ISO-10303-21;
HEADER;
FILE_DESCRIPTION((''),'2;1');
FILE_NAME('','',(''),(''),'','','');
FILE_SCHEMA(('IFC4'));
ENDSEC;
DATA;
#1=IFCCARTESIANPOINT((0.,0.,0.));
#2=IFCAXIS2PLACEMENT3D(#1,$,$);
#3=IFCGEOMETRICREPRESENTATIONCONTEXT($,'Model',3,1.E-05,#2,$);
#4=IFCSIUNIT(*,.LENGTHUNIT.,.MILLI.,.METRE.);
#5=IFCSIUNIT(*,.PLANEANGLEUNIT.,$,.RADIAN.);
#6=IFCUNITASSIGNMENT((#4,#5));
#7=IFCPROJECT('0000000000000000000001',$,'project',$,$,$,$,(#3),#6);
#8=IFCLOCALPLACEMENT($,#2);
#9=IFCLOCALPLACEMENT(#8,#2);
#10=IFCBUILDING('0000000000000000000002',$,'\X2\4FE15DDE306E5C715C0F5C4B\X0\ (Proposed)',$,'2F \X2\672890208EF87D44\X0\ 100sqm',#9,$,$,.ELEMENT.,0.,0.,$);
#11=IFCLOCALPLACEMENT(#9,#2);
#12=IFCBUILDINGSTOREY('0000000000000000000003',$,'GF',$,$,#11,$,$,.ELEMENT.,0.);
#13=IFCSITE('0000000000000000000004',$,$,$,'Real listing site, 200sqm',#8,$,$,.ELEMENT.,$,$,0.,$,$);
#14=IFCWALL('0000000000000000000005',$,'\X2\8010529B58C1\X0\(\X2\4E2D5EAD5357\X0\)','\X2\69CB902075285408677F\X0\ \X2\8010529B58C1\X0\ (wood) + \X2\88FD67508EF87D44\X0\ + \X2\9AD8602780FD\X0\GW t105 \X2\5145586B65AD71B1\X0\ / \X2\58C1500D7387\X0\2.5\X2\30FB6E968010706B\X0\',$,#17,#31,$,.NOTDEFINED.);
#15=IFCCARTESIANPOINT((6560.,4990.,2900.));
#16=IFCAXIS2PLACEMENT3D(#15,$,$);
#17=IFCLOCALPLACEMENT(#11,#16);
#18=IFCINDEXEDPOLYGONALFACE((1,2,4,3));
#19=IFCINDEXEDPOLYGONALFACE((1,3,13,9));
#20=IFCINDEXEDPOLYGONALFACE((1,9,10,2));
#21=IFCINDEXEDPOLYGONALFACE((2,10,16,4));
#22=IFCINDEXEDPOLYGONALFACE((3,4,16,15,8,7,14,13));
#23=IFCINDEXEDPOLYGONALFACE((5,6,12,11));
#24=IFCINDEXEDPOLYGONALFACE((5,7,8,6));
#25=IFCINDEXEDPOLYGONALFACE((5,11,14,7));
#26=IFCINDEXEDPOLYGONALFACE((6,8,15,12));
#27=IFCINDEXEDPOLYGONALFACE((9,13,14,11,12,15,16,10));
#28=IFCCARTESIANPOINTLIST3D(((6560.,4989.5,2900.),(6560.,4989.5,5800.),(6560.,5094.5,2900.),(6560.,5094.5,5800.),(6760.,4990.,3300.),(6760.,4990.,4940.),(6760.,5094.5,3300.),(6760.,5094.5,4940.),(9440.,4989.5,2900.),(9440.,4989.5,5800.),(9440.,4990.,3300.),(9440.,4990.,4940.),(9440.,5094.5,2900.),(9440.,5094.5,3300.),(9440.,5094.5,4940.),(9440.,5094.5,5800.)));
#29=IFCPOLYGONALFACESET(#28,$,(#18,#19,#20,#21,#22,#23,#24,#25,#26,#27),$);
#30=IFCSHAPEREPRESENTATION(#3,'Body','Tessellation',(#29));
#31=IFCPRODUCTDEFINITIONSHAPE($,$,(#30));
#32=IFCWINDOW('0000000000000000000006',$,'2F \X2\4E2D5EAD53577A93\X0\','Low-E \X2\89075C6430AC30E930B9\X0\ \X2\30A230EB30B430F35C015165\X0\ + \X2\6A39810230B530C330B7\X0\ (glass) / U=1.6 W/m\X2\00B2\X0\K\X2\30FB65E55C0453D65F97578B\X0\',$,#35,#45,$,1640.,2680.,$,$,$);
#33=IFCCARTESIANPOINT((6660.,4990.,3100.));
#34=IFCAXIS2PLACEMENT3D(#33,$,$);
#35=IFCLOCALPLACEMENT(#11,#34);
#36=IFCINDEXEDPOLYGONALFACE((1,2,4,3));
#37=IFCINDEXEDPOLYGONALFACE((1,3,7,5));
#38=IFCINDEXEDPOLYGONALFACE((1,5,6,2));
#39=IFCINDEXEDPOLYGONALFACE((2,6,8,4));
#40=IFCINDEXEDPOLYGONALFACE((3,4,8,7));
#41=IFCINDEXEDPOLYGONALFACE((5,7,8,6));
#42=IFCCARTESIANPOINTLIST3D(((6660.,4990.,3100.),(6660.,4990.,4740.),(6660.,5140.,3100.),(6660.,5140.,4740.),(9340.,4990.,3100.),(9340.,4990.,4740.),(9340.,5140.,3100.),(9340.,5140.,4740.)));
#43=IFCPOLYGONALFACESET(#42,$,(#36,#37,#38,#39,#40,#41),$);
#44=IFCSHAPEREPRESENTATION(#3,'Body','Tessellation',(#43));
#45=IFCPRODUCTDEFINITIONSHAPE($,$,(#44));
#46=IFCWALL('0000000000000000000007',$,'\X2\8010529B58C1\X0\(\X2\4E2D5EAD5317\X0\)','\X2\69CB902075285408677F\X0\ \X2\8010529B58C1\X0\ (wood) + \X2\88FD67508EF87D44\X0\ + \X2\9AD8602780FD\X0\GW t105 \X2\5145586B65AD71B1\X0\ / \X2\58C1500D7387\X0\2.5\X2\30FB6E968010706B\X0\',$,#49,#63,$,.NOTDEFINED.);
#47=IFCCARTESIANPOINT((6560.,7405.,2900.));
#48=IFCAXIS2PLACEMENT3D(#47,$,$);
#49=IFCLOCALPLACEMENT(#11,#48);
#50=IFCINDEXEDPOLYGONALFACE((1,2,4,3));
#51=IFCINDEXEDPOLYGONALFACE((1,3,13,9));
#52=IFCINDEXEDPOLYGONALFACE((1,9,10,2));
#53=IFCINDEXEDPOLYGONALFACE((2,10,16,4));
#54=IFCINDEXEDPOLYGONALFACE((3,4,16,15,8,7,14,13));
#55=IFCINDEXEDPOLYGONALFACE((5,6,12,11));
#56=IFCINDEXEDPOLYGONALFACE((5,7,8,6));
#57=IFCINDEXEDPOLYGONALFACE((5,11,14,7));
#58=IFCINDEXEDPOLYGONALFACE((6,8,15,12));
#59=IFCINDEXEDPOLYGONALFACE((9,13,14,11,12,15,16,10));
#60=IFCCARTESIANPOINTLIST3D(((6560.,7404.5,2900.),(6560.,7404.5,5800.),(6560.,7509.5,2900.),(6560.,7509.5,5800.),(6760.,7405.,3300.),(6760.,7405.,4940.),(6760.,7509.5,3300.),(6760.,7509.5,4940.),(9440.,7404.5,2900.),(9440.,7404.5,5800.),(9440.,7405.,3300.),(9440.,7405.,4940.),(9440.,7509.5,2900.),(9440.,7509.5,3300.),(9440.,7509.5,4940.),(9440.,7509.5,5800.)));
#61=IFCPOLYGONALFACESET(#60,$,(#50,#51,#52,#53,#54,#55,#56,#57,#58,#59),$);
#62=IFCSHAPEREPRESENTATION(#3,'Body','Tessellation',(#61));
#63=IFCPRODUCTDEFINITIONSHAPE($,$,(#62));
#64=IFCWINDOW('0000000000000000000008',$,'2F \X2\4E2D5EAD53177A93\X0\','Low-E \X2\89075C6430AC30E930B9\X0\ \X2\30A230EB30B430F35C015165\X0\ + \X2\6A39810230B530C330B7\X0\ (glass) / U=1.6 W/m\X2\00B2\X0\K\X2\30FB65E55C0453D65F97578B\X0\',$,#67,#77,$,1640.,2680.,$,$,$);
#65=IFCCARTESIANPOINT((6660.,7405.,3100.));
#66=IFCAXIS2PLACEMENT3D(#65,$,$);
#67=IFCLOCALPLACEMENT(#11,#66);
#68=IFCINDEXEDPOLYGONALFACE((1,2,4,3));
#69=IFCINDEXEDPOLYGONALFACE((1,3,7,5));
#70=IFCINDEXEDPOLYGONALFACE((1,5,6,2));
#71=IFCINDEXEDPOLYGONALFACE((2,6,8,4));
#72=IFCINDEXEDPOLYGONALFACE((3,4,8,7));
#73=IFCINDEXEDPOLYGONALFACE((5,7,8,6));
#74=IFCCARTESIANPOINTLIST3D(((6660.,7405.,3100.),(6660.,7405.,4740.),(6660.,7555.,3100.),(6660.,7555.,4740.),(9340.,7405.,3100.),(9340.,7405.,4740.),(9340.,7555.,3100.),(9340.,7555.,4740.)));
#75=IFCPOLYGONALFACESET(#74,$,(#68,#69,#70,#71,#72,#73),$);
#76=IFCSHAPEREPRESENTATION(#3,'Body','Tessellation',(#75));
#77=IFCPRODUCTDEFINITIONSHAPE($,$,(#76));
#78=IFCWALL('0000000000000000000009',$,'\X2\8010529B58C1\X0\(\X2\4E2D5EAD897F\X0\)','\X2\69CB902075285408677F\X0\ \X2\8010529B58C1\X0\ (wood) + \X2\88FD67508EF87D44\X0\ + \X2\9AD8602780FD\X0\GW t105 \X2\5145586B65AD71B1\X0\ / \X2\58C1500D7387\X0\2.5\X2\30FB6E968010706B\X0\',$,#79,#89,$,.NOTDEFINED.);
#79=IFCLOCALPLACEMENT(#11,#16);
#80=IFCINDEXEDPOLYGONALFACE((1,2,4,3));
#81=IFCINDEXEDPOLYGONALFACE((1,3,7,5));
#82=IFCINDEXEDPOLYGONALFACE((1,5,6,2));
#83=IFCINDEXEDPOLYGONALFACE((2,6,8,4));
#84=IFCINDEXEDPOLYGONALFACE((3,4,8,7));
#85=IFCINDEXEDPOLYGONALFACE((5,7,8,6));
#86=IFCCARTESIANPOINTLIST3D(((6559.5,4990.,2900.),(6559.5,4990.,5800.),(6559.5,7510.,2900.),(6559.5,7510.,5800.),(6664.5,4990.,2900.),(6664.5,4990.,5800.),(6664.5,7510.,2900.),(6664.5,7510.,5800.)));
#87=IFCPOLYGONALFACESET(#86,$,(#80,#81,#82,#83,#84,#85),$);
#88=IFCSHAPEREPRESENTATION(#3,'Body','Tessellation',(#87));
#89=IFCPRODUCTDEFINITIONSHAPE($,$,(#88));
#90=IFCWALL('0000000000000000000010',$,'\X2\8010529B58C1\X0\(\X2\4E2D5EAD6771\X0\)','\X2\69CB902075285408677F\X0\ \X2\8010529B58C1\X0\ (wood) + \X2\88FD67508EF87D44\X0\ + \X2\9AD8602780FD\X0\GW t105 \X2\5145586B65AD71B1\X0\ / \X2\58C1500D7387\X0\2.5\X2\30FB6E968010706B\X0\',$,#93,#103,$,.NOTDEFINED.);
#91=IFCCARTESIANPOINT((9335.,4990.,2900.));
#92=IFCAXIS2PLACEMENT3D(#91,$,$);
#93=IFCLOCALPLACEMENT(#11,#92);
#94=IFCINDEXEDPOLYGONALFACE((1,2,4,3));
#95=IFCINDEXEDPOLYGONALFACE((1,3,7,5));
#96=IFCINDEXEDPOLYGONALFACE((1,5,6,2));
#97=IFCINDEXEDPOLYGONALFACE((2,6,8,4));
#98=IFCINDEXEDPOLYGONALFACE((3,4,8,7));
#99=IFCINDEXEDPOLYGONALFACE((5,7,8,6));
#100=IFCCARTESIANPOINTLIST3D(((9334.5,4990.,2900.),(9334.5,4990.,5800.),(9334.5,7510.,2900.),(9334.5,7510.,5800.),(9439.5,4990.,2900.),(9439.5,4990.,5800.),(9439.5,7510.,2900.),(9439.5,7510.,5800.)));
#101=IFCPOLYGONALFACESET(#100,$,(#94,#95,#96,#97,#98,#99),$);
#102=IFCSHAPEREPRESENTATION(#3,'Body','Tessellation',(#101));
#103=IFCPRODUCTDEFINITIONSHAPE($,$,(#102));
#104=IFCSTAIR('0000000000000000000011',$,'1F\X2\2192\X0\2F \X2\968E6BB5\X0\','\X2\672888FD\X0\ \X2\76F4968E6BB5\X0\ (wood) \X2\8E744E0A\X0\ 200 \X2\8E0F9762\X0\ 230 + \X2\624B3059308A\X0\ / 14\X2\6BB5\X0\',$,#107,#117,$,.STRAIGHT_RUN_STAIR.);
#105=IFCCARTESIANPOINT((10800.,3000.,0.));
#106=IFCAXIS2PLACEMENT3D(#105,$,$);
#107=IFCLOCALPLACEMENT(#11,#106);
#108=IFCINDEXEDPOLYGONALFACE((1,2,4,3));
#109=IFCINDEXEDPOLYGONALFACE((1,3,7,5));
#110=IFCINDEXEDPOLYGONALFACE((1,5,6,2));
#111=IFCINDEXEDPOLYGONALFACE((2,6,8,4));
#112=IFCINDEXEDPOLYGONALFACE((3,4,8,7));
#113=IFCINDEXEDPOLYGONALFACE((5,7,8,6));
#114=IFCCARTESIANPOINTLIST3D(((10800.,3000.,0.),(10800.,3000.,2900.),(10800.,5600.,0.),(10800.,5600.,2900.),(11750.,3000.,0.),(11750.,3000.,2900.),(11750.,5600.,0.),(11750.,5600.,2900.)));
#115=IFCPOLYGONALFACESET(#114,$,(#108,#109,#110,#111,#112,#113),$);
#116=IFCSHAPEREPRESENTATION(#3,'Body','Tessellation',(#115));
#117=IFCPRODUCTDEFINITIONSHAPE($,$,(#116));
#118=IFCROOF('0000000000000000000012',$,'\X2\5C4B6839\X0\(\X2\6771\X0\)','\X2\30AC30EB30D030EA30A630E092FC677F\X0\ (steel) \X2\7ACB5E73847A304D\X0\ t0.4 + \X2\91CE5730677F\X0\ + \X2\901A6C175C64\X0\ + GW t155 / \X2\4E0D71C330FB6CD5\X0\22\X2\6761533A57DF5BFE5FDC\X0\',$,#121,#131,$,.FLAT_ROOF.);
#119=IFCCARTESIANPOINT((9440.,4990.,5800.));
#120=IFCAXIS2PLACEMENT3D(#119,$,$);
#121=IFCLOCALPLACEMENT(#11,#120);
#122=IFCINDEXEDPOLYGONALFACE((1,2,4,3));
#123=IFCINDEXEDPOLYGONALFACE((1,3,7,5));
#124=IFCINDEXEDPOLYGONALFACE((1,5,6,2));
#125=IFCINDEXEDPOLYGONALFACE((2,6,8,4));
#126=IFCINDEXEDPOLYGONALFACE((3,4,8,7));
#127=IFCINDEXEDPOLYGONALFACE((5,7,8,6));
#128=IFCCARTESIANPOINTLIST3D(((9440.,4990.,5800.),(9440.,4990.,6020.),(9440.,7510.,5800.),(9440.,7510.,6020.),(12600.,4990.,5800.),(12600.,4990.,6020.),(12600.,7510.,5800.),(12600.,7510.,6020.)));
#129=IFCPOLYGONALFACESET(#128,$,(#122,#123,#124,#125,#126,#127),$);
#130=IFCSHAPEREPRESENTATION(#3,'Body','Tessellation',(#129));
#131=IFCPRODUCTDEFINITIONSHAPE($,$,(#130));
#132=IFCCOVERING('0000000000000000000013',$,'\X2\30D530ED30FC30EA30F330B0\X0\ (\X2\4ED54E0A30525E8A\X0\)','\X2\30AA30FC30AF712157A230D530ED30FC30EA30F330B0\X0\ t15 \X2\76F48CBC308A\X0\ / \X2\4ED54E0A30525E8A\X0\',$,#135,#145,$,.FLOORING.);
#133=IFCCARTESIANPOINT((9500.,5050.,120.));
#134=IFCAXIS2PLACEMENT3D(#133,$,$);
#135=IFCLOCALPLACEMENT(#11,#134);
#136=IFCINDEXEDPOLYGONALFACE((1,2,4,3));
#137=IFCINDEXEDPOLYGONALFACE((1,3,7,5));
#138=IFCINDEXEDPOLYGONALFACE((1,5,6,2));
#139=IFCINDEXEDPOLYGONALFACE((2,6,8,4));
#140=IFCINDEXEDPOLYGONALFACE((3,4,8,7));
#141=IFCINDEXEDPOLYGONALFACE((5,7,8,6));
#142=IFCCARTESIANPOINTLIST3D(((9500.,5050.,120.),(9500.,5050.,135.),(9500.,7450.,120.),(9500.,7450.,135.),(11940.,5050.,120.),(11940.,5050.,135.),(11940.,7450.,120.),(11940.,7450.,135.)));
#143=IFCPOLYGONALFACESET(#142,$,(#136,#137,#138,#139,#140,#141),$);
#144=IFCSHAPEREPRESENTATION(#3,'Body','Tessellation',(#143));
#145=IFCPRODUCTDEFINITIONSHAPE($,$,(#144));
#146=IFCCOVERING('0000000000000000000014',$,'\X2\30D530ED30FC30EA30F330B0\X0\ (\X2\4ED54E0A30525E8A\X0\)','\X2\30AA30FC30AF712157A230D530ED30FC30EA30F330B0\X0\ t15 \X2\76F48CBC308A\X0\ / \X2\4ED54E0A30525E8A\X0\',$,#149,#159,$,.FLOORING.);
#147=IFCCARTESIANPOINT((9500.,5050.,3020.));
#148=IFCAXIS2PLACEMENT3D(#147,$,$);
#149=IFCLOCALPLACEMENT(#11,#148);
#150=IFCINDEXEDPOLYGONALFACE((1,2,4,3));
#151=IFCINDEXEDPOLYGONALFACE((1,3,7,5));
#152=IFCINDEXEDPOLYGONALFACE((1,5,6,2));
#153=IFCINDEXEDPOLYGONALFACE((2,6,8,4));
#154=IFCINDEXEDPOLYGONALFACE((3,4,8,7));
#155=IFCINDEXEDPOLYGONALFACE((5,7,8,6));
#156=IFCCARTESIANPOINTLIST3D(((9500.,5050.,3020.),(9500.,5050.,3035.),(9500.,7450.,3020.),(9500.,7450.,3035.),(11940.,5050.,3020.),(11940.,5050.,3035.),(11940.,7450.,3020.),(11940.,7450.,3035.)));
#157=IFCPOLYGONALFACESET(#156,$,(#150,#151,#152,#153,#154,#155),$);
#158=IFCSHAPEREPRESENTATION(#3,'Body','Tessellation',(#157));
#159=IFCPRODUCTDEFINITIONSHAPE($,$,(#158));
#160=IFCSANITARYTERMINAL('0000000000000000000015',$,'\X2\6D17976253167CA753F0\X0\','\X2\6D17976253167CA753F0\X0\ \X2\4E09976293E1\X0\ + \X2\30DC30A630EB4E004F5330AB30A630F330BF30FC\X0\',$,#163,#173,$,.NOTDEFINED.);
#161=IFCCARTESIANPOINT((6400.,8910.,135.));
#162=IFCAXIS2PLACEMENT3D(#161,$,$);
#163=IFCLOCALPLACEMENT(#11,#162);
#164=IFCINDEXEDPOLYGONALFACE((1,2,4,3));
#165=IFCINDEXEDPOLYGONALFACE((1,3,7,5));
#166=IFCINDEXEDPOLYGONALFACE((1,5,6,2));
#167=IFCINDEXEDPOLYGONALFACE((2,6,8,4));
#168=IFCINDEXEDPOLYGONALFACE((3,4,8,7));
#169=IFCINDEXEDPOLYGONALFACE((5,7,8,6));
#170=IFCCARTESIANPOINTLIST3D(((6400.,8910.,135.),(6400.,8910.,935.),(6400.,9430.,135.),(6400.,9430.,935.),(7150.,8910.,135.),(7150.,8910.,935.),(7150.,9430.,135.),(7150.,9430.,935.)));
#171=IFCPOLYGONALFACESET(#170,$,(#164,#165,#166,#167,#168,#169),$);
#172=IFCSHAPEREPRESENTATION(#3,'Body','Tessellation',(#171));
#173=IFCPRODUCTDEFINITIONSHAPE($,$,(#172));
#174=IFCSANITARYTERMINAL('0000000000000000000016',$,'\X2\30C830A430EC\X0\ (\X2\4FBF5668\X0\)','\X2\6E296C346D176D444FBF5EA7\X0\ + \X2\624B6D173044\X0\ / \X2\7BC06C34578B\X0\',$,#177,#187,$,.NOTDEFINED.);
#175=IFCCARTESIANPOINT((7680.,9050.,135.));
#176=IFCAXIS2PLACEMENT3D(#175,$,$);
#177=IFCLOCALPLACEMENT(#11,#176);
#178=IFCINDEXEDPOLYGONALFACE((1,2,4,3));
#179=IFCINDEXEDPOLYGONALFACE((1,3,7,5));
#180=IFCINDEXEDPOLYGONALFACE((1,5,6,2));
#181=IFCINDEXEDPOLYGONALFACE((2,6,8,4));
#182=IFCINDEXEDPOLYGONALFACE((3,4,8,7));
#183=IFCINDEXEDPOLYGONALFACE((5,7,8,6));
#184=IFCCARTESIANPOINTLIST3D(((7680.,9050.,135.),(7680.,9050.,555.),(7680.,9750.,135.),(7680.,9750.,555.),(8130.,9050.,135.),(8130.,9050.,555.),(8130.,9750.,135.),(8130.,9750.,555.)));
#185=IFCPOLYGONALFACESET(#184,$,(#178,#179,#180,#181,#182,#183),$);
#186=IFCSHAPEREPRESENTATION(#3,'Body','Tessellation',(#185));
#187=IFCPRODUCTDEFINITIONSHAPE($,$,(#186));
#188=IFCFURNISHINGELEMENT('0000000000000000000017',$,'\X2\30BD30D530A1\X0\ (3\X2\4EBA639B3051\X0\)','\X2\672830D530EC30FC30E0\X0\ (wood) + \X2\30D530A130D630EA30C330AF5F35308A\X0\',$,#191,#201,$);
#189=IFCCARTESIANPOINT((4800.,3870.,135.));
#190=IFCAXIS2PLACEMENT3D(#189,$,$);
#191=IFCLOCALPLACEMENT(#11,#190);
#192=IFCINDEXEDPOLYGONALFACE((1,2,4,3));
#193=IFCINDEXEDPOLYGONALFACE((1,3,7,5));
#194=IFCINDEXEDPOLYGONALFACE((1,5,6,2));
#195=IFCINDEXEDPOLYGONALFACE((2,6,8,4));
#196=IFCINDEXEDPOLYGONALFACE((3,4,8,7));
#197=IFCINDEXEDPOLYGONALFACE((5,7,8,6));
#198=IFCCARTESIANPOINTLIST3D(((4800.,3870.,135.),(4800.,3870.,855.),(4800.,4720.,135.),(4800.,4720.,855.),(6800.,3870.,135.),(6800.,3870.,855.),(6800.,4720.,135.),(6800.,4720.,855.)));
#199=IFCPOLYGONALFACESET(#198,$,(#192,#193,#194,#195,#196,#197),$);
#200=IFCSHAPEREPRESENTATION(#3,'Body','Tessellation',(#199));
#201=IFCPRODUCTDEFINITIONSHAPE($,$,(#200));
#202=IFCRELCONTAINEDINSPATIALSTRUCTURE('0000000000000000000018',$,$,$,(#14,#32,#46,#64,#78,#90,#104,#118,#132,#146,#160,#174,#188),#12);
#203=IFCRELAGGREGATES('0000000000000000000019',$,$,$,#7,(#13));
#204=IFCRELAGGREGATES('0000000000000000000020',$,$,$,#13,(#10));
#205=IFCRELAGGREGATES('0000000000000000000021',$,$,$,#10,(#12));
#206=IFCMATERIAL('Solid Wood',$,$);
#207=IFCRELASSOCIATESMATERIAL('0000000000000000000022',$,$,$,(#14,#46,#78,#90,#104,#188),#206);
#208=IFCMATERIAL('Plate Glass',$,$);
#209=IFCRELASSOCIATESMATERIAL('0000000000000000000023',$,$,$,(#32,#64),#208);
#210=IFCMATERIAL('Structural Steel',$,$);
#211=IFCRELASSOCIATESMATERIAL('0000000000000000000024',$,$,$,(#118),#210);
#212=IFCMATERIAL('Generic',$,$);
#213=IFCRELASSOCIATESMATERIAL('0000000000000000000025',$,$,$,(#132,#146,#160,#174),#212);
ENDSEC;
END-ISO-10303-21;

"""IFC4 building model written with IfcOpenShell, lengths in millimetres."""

from ifc_helpers import new_model, si_unit, frame, frame_2d, origin, place, context, project, spatial, rectangle, extrude, material, element, fill, save


model = new_model("IFC4")

# Units and contexts
model_context = context("Model", 3, precision=1e-05, world=origin())
ifc_project = project(units=[si_unit("LENGTHUNIT", "METRE", prefix="MILLI"), si_unit("PLANEANGLEUNIT", "RADIAN")], contexts=[model_context])

# Site, building, storey
site_placement = place(None, origin())
site = spatial("IfcSite", under=ifc_project, at=site_placement, ObjectType="Real listing site, 200sqm", CompositionType="ELEMENT", RefElevation=0.0)
building_placement = place(site_placement, origin())
building = spatial("IfcBuilding", under=site, at=building_placement, Name="信州の山小屋 (Proposed)", ObjectType="2F 木造軸組 100sqm", CompositionType="ELEMENT", ElevationOfRefHeight=0.0, ElevationOfTerrain=0.0)
storey_placement = place(building_placement, origin())
storey = spatial("IfcBuildingStorey", under=building, at=storey_placement, Name="GF", CompositionType="ELEMENT", Elevation=0.0)

# Shared definitions
ifc_material_1 = material(Name="Solid Wood")

# Shared definitions
ifc_material_2 = material(Name="Plate Glass")

# Walls, openings, windows
wall_1_placement = place(storey_placement, frame((6560.0, 4990.0, 2900.0)))
wall_1 = element("IfcWall", 1, at=wall_1_placement, inside=storey, material=ifc_material_1, Name="耐力壁(中庭南)", Description="構造用合板 耐力壁 (wood) + 製材軸組 + 高性能GW t105 充填断熱 / 壁倍率2.5・準耐火", PredefinedType="NOTDEFINED", context=model_context, shape_type="SweptSolid", body=[
    extrude(rectangle(XDim=2880.0, YDim=105.0, at=frame_2d((1440.0, 52.0))), frame((6560.0, 4990.0, 2900.0)), (0.0, 0.0, 1.0), 2900.0),
])
opening_1_placement = place(storey_placement, frame((6660.0, 4990.0, 3100.0)))
opening_1 = element("IfcOpeningElement", 2, at=opening_1_placement, cuts=wall_1, PredefinedType="NOTDEFINED", context=model_context, shape_type="SweptSolid", body=[
    extrude(rectangle(XDim=2680.0, YDim=150.0, at=frame_2d((1340.0, 75.0))), frame((6660.0, 4990.0, 3100.0)), (0.0, 0.0, 1.0), 1640.0),
])
window_1_placement = place(storey_placement, frame((6660.0, 4990.0, 3100.0)))
window_1 = element("IfcWindow", 3, at=window_1_placement, inside=storey, material=ifc_material_2, Name="2F 中庭南窓", Description="Low-E 複層ガラス アルゴン封入 + 樹脂サッシ (glass) / U=1.6 W/m²K・日射取得型", OverallHeight=1640.0, OverallWidth=2680.0, context=model_context, shape_type="SweptSolid", body=[
    extrude(rectangle(XDim=2680.0, YDim=150.0, at=frame_2d((1340.0, 75.0))), frame((6660.0, 4990.0, 3100.0)), (0.0, 0.0, 1.0), 1640.0),
])
fill(opening_1, window_1)
wall_2_placement = place(storey_placement, frame((6560.0, 7405.0, 2900.0)))
wall_2 = element("IfcWall", 4, at=wall_2_placement, inside=storey, material=ifc_material_1, Name="耐力壁(中庭北)", Description="構造用合板 耐力壁 (wood) + 製材軸組 + 高性能GW t105 充填断熱 / 壁倍率2.5・準耐火", PredefinedType="NOTDEFINED", context=model_context, shape_type="SweptSolid", body=[
    extrude(rectangle(XDim=2880.0, YDim=105.0, at=frame_2d((1440.0, 52.0))), frame((6560.0, 7405.0, 2900.0)), (0.0, 0.0, 1.0), 2900.0),
])
opening_2_placement = place(storey_placement, frame((6660.0, 7405.0, 3100.0)))
opening_2 = element("IfcOpeningElement", 5, at=opening_2_placement, cuts=wall_2, PredefinedType="NOTDEFINED", context=model_context, shape_type="SweptSolid", body=[
    extrude(rectangle(XDim=2680.0, YDim=150.0, at=frame_2d((1340.0, 75.0))), frame((6660.0, 7405.0, 3100.0)), (0.0, 0.0, 1.0), 1640.0),
])
window_2_placement = place(storey_placement, frame((6660.0, 7405.0, 3100.0)))
window_2 = element("IfcWindow", 6, at=window_2_placement, inside=storey, material=ifc_material_2, Name="2F 中庭北窓", Description="Low-E 複層ガラス アルゴン封入 + 樹脂サッシ (glass) / U=1.6 W/m²K・日射取得型", OverallHeight=1640.0, OverallWidth=2680.0, context=model_context, shape_type="SweptSolid", body=[
    extrude(rectangle(XDim=2680.0, YDim=150.0, at=frame_2d((1340.0, 75.0))), frame((6660.0, 7405.0, 3100.0)), (0.0, 0.0, 1.0), 1640.0),
])
fill(opening_2, window_2)

# Walls
wall_3_placement = place(storey_placement, frame((6560.0, 4990.0, 2900.0)))
element("IfcWall", 7, at=wall_3_placement, inside=storey, material=ifc_material_1, Name="耐力壁(中庭西)", Description="構造用合板 耐力壁 (wood) + 製材軸組 + 高性能GW t105 充填断熱 / 壁倍率2.5・準耐火", PredefinedType="NOTDEFINED", context=model_context, shape_type="SweptSolid", body=[
    extrude(rectangle(XDim=105.0, YDim=2520.0, at=frame_2d((52.0, 1260.0))), frame((6560.0, 4990.0, 2900.0)), (0.0, 0.0, 1.0), 2900.0),
])
wall_4_placement = place(storey_placement, frame((9335.0, 4990.0, 2900.0)))
element("IfcWall", 8, at=wall_4_placement, inside=storey, material=ifc_material_1, Name="耐力壁(中庭東)", Description="構造用合板 耐力壁 (wood) + 製材軸組 + 高性能GW t105 充填断熱 / 壁倍率2.5・準耐火", PredefinedType="NOTDEFINED", context=model_context, shape_type="SweptSolid", body=[
    extrude(rectangle(XDim=105.0, YDim=2520.0, at=frame_2d((52.0, 1260.0))), frame((9335.0, 4990.0, 2900.0)), (0.0, 0.0, 1.0), 2900.0),
])

# Stair
stair_placement = place(storey_placement, frame((10800.0, 3000.0, 0.0)))
element("IfcStair", 9, at=stair_placement, inside=storey, material=ifc_material_1, Name="1F→2F 階段", Description="木製 直階段 (wood) 蹴上 200 踏面 230 + 手すり / 14段", PredefinedType="STRAIGHT_RUN_STAIR", context=model_context, shape_type="SweptSolid", body=[
    extrude(rectangle(XDim=950.0, YDim=2600.0, at=frame_2d((475.0, 1300.0))), frame((10800.0, 3000.0, 0.0)), (0.0, 0.0, 1.0), 2900.0),
])

# Roof
ifc_material_3 = material(Name="Structural Steel")
for number, where, name in (
    (10, (9440.0, 4990.0, 5800.0), "屋根(東)"),
):
    element("IfcRoof", number, at=place(storey_placement, frame(where)), inside=storey, material=ifc_material_3, Name=name, Description="ガルバリウム鋼板 (steel) 立平葺き t0.4 + 野地板 + 通気層 + GW t155 / 不燃・法22条区域対応", PredefinedType="FLAT_ROOF", context=model_context, shape_type="SweptSolid", body=[
        extrude(rectangle(XDim=3160.0, YDim=2520.0, at=frame_2d((1580.0, 1260.0))), frame((9440.0, 4990.0, 5800.0)), (0.0, 0.0, 1.0), 220.0),
    ])

# Coverings
ifc_material_4 = material(Name="Generic")
covering_1_placement = place(storey_placement, frame((9500.0, 5050.0, 120.0)))
element("IfcCovering", 11, at=covering_1_placement, inside=storey, material=ifc_material_4, Name="フローリング (仕上げ床)", Description="オーク無垢フローリング t15 直貼り / 仕上げ床", PredefinedType="FLOORING", context=model_context, shape_type="SweptSolid", body=[
    extrude(rectangle(XDim=2440.0, YDim=2400.0, at=frame_2d((1220.0, 1200.0))), frame((9500.0, 5050.0, 120.0)), (0.0, 0.0, 1.0), 15.0),
])
covering_2_placement = place(storey_placement, frame((9500.0, 5050.0, 3020.0)))
element("IfcCovering", 12, at=covering_2_placement, inside=storey, material=ifc_material_4, Name="フローリング (仕上げ床)", Description="オーク無垢フローリング t15 直貼り / 仕上げ床", PredefinedType="FLOORING", context=model_context, shape_type="SweptSolid", body=[
    extrude(rectangle(XDim=2440.0, YDim=2400.0, at=frame_2d((1220.0, 1200.0))), frame((9500.0, 5050.0, 3020.0)), (0.0, 0.0, 1.0), 15.0),
])

# Sanitary terminals
sanitary_terminal_1_placement = place(storey_placement, frame((6400.0, 8910.0, 135.0)))
element("IfcSanitaryTerminal", 13, at=sanitary_terminal_1_placement, inside=storey, material=ifc_material_4, Name="洗面化粧台", Description="洗面化粧台 三面鏡 + ボウル一体カウンター", PredefinedType="NOTDEFINED", context=model_context, shape_type="SweptSolid", body=[
    extrude(rectangle(XDim=750.0, YDim=520.0, at=frame_2d((375.0, 260.0))), frame((6400.0, 8910.0, 135.0)), (0.0, 0.0, 1.0), 800.0),
])
sanitary_terminal_2_placement = place(storey_placement, frame((7680.0, 9050.0, 135.0)))
element("IfcSanitaryTerminal", 14, at=sanitary_terminal_2_placement, inside=storey, material=ifc_material_4, Name="トイレ (便器)", Description="温水洗浄便座 + 手洗い / 節水型", PredefinedType="NOTDEFINED", context=model_context, shape_type="SweptSolid", body=[
    extrude(rectangle(XDim=450.0, YDim=700.0, at=frame_2d((225.0, 350.0))), frame((7680.0, 9050.0, 135.0)), (0.0, 0.0, 1.0), 420.0),
])

# Furnishing element
furnishing_1_placement = place(storey_placement, frame((4800.0, 3870.0, 135.0)))
element("IfcFurnishingElement", 15, at=furnishing_1_placement, inside=storey, material=ifc_material_1, Name="ソファ (3人掛け)", Description="木フレーム (wood) + ファブリック張り", context=model_context, shape_type="SweptSolid", body=[
    extrude(rectangle(XDim=2000.0, YDim=850.0, at=frame_2d((1000.0, 425.0))), frame((4800.0, 3870.0, 135.0)), (0.0, 0.0, 1.0), 720.0),
])

save(model, "model.ifc")
